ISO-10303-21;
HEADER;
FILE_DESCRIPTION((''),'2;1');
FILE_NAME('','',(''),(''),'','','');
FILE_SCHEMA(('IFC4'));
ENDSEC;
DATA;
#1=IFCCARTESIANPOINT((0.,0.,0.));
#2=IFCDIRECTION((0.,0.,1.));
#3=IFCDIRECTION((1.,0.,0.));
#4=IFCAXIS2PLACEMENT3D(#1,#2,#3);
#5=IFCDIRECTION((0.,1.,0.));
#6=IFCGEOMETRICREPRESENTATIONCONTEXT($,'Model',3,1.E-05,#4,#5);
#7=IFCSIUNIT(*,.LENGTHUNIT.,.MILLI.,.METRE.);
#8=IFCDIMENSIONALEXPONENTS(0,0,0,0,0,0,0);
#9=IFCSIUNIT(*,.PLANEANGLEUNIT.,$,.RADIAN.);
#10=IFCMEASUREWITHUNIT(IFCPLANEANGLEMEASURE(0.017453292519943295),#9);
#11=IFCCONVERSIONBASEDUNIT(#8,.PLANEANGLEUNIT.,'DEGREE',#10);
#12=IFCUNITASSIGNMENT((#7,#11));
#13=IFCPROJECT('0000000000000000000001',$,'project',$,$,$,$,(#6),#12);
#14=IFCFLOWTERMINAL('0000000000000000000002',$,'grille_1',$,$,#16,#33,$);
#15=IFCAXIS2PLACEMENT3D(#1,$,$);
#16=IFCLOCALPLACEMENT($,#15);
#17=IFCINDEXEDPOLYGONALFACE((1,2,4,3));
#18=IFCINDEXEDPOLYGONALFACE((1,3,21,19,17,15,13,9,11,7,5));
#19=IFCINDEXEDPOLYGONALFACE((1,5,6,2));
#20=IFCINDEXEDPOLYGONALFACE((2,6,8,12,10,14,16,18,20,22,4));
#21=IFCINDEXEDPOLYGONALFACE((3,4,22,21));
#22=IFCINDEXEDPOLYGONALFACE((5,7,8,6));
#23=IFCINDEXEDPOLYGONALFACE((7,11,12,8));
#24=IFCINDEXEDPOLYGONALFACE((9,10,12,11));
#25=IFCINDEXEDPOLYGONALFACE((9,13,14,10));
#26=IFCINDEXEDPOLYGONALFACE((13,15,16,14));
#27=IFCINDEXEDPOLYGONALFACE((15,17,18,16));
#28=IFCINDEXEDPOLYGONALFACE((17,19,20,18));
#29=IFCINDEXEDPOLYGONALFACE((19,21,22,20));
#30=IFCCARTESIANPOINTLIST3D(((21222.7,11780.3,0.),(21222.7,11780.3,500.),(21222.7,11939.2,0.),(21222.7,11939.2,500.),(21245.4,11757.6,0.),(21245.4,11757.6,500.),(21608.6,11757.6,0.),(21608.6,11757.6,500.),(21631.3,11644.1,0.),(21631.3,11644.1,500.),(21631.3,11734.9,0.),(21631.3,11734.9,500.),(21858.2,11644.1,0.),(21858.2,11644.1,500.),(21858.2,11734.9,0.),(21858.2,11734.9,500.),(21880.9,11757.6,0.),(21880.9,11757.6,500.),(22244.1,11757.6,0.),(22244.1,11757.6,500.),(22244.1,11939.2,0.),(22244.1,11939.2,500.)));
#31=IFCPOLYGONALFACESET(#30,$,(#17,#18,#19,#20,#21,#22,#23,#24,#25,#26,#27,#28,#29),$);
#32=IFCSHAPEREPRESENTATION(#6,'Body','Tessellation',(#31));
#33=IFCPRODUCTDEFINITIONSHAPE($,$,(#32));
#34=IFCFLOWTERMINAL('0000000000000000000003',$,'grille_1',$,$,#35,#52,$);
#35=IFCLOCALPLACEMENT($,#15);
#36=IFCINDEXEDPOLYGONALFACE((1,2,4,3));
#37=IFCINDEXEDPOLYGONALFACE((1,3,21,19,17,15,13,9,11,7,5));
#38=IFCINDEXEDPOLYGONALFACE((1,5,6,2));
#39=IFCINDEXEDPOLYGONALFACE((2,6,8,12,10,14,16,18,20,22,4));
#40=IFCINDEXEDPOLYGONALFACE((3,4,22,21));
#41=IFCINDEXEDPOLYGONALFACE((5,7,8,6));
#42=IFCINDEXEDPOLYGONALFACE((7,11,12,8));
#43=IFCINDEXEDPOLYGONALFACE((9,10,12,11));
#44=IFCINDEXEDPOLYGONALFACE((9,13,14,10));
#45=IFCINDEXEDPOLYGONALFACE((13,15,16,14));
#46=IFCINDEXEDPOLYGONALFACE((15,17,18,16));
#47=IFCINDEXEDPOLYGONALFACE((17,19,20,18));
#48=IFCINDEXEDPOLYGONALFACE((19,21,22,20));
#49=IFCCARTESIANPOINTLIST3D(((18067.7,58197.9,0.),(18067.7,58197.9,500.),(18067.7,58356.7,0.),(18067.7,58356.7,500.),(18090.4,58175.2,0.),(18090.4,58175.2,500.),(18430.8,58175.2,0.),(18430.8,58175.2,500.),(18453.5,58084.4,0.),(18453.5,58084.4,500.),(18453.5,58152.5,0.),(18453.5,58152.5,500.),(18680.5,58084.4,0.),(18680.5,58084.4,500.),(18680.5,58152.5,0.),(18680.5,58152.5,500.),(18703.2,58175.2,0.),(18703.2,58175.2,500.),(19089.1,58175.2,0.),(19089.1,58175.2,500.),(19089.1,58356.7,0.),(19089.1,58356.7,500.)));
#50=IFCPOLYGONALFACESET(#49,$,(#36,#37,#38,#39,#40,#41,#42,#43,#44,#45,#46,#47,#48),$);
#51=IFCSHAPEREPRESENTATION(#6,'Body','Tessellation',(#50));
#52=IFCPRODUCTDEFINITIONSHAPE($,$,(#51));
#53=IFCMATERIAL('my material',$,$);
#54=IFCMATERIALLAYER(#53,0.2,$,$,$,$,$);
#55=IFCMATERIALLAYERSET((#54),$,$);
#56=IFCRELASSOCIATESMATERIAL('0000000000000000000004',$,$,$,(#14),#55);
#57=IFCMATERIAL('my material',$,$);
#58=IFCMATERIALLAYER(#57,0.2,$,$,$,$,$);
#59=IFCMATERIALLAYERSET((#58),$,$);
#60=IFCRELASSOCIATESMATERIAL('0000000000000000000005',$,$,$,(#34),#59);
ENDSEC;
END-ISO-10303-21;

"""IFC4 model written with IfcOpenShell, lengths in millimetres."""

from ifc_helpers import new_model, entity, si_unit, converted_unit, direction, origin_with_axes, place, context, project, polyline, outline, extrude, material, layer, layer_set, layer_usage, element, save


model = new_model("IFC4")

# Units and contexts
model_context = context("Model", 3, precision=1e-05, world=origin_with_axes(), true_north=direction((0.0, 1.0, 0.0)))
ifc_project = project(units=[si_unit("LENGTHUNIT", "METRE", prefix="MILLI"), converted_unit("PLANEANGLEUNIT", "DEGREE", entity("IfcPlaneAngleMeasure", 0.017453292519943295), si_unit("PLANEANGLEUNIT", "RADIAN"), dimensions=[0, 0, 0, 0, 0, 0, 0])], contexts=[model_context])

# Flow terminals
ifc_material_1 = material(Name="my material")
ifc_layer_1 = layer(ifc_material_1, 0.2)
ifc_layer_set_1 = layer_set([ifc_layer_1])
ifc_layer_usage_1 = layer_usage(ifc_layer_set_1, "AXIS2", "POSITIVE", -0.1)
flow_terminal_1_placement = place(None, origin_with_axes())
element("IfcFlowTerminal", 1, at=flow_terminal_1_placement, material=ifc_layer_usage_1, Name="grille_1", context=model_context, shape_type="SweptSolid", body=[
    extrude(outline(polyline([(21222.7, 11780.3), (21245.4, 11757.6), (21608.6, 11757.6), (21631.3, 11734.9), (21631.3, 11644.1), (21858.2, 11644.1), (21858.2, 11734.9), (21880.9, 11757.6), (22244.1, 11757.6), (22244.1, 11939.2), (21222.7, 11939.2), (21222.7, 11780.3)])), origin_with_axes(), (0.0, 0.0, 1.0), 500.0),
])
ifc_material_2 = material(Name="my material")
ifc_layer_2 = layer(ifc_material_2, 0.2)
ifc_layer_set_2 = layer_set([ifc_layer_2])
ifc_layer_usage_2 = layer_usage(ifc_layer_set_2, "AXIS2", "POSITIVE", -0.1)
flow_terminal_2_placement = place(None, origin_with_axes())
element("IfcFlowTerminal", 2, at=flow_terminal_2_placement, material=ifc_layer_usage_2, Name="grille_1", context=model_context, shape_type="SweptSolid", body=[
    extrude(outline(polyline([(18067.7, 58197.9), (18090.4, 58175.2), (18430.8, 58175.2), (18453.5, 58152.5), (18453.5, 58084.4), (18680.5, 58084.4), (18680.5, 58152.5), (18703.2, 58175.2), (19089.1, 58175.2), (19089.1, 58356.7), (18067.7, 58356.7), (18067.7, 58197.9)])), origin_with_axes(), (0.0, 0.0, 1.0), 500.0),
])

save(model, "model.ifc")
